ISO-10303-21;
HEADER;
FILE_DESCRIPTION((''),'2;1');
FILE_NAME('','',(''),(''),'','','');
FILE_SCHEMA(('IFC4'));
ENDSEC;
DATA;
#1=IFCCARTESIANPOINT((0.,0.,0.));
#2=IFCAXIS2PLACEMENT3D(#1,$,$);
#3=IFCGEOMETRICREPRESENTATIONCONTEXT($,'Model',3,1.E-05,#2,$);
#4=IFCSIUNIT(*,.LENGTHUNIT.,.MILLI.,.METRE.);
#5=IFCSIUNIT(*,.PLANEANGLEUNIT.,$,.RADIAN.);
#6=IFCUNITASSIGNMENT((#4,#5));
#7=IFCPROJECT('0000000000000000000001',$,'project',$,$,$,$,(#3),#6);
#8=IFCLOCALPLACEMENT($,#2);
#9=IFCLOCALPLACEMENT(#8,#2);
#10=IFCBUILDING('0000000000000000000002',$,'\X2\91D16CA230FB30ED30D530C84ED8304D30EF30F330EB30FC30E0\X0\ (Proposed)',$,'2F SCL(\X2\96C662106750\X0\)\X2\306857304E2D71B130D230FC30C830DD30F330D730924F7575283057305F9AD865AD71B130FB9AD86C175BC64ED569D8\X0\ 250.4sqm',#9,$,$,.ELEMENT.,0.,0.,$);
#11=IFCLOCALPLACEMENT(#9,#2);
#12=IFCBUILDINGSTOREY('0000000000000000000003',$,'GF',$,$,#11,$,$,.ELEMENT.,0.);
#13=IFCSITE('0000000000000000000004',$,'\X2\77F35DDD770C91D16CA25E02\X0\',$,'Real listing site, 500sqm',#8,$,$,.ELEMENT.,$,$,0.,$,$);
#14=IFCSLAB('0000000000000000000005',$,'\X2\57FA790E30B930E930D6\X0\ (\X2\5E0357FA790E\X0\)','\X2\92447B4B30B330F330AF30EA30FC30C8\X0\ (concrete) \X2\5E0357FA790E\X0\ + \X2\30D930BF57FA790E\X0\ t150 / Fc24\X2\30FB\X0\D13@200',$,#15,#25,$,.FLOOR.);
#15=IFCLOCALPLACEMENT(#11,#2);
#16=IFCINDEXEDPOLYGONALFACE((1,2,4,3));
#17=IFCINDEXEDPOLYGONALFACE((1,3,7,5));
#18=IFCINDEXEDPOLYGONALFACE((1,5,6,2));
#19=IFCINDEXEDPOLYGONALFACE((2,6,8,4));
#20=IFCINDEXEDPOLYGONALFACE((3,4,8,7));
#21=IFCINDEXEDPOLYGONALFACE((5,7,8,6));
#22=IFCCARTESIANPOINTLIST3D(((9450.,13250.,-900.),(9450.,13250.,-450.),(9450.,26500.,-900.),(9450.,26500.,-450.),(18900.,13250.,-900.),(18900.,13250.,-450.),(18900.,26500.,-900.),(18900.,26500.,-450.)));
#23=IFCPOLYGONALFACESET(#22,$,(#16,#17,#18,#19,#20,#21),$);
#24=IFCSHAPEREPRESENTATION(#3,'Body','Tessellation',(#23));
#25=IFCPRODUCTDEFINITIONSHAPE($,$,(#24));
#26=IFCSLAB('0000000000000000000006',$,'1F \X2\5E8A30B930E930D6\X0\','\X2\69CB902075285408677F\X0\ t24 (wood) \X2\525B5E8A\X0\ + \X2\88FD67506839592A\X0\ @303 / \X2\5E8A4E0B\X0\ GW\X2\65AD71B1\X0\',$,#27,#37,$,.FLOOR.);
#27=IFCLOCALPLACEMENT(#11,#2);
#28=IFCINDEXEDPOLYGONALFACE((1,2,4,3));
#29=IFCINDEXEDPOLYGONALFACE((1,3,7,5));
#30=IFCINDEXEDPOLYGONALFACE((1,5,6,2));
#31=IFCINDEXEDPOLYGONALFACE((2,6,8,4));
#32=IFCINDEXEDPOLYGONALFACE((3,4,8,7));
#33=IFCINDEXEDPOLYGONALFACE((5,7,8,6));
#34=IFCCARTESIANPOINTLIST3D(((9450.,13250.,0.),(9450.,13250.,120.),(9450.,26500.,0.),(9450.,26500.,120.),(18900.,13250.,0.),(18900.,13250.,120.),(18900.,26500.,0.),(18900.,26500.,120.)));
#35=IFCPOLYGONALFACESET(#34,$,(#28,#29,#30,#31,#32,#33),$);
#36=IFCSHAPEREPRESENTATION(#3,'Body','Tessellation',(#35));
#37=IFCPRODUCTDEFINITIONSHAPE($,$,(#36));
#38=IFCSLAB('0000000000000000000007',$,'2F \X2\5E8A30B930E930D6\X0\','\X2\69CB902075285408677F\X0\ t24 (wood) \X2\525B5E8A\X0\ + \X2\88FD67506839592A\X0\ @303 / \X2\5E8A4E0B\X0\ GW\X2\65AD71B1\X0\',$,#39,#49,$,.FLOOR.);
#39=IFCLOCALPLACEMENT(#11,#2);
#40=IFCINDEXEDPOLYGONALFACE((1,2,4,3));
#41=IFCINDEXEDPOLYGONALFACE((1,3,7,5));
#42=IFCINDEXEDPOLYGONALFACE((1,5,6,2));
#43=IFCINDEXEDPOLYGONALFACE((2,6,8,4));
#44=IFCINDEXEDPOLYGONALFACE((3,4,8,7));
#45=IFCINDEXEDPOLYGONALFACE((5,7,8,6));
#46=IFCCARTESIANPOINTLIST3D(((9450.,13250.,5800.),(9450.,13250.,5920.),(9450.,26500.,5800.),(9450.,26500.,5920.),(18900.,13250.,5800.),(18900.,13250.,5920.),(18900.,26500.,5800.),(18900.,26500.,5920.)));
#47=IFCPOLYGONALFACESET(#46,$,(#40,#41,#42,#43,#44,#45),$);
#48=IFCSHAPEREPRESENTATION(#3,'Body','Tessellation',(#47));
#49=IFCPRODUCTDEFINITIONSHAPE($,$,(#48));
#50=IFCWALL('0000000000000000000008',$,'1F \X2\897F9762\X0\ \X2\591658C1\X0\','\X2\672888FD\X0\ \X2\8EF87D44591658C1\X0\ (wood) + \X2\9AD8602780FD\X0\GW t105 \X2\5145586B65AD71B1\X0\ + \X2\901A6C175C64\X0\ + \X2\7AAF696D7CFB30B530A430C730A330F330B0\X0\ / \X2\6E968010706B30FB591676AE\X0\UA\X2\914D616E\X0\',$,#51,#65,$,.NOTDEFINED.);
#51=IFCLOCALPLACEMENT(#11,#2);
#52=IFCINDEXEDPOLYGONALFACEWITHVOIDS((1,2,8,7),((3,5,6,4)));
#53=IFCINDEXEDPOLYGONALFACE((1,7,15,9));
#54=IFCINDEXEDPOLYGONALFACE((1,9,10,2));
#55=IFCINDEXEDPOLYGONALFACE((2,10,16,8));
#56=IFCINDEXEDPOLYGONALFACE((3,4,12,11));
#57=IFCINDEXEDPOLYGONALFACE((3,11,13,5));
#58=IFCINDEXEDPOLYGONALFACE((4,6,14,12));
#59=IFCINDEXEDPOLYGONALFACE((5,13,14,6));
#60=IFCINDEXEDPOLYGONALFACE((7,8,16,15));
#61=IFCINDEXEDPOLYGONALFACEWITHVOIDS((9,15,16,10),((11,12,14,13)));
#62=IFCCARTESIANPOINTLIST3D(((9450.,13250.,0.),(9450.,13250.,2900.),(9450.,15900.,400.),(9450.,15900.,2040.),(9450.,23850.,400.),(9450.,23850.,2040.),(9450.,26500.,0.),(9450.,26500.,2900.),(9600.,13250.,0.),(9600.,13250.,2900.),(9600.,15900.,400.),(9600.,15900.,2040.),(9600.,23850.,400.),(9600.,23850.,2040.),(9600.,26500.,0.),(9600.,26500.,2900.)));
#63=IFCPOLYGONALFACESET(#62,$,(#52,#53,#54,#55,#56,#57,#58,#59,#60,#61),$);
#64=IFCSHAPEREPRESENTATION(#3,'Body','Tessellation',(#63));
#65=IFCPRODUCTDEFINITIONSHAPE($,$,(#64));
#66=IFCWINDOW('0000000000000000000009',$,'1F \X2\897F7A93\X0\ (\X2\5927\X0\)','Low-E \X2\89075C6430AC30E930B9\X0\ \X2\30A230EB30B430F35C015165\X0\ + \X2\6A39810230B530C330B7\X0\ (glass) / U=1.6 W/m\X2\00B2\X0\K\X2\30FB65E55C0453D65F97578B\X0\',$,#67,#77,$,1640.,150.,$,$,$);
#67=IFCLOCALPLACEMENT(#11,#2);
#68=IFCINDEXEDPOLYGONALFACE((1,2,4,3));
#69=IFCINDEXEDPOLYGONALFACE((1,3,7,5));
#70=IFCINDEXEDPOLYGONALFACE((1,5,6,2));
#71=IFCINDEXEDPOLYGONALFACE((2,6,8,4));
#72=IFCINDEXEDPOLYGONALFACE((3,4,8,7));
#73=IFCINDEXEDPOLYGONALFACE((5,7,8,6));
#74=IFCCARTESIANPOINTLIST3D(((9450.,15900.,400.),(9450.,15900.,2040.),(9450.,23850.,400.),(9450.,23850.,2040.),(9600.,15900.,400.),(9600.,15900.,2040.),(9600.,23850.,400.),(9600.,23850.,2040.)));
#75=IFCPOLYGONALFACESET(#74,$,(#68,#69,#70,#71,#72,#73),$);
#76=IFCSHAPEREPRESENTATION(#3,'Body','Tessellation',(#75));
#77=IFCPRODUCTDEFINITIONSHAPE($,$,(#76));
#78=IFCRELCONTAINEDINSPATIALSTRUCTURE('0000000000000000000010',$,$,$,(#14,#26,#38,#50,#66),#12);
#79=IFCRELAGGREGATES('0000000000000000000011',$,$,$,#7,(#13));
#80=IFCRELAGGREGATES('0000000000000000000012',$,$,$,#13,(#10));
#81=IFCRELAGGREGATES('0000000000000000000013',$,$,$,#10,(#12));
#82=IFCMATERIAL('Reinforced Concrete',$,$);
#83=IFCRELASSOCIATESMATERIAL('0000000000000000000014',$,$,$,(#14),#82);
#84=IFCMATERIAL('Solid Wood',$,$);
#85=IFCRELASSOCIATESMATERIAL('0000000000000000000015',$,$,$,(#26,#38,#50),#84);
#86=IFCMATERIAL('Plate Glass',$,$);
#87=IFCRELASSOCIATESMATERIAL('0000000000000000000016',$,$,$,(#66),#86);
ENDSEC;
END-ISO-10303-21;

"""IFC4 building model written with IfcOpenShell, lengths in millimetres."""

from ifc_helpers import new_model, si_unit, frame, frame_2d, origin, place, context, project, spatial, rectangle, extrude, material, element, fill, save


model = new_model("IFC4")

# Units and contexts
model_context = context("Model", 3, precision=1e-05, world=origin())
ifc_project = project(units=[si_unit("LENGTHUNIT", "METRE", prefix="MILLI"), si_unit("PLANEANGLEUNIT", "RADIAN")], contexts=[model_context])

# Site, building, storey
site_placement = place(None, origin())
site = spatial("IfcSite", under=ifc_project, at=site_placement, Name="石川県金沢市", ObjectType="Real listing site, 500sqm", CompositionType="ELEMENT", RefElevation=0.0)
building_placement = place(site_placement, origin())
building = spatial("IfcBuilding", under=site, at=building_placement, Name="金沢・ロフト付きワンルーム (Proposed)", ObjectType="2F SCL(集成材)と地中熱ヒートポンプを併用した高断熱・高気密仕様 250.4sqm", CompositionType="ELEMENT", ElevationOfRefHeight=0.0, ElevationOfTerrain=0.0)
storey_placement = place(building_placement, origin())
storey = spatial("IfcBuildingStorey", under=building, at=storey_placement, Name="GF", CompositionType="ELEMENT", Elevation=0.0)

# Shared definitions
ifc_material_1 = material(Name="Solid Wood")

# Slabs
ifc_material_2 = material(Name="Reinforced Concrete")
slab_1_placement = place(storey_placement, frame((4725.0, 6625.0, -450.0)))
element("IfcSlab", 1, at=slab_1_placement, inside=storey, material=ifc_material_2, Name="基礎スラブ (布基礎)", Description="鉄筋コンクリート (concrete) 布基礎 + ベタ基礎 t150 / Fc24・D13@200", PredefinedType="FLOOR", context=model_context, shape_type="SweptSolid", body=[
    extrude(rectangle(XDim=9450.0, YDim=13250.0, at=frame_2d((4725.0, 6625.0))), frame((4725.0, 6625.0, -450.0)), (0.0, 0.0, 1.0), 450.0),
])
slab_2_placement = place(storey_placement, frame((4725.0, 6625.0, 0.0)))
element("IfcSlab", 2, at=slab_2_placement, inside=storey, material=ifc_material_1, Name="1F 床スラブ", Description="構造用合板 t24 (wood) 剛床 + 製材根太 @303 / 床下 GW断熱", PredefinedType="FLOOR", context=model_context, shape_type="SweptSolid", body=[
    extrude(rectangle(XDim=9450.0, YDim=13250.0, at=frame_2d((4725.0, 6625.0))), frame((4725.0, 6625.0, 0.0)), (0.0, 0.0, 1.0), 120.0),
])
slab_3_placement = place(storey_placement, frame((4725.0, 6625.0, 2900.0)))
element("IfcSlab", 3, at=slab_3_placement, inside=storey, material=ifc_material_1, Name="2F 床スラブ", Description="構造用合板 t24 (wood) 剛床 + 製材根太 @303 / 床下 GW断熱", PredefinedType="FLOOR", context=model_context, shape_type="SweptSolid", body=[
    extrude(rectangle(XDim=9450.0, YDim=13250.0, at=frame_2d((4725.0, 6625.0))), frame((4725.0, 6625.0, 2900.0)), (0.0, 0.0, 1.0), 120.0),
])

# Shared definitions
ifc_material_3 = material(Name="Plate Glass")

# Wall, opening, window
wall_1_placement = place(storey_placement, frame((4725.0, 6625.0, 0.0)))
wall_1 = element("IfcWall", 4, at=wall_1_placement, inside=storey, material=ifc_material_1, Name="1F 西面 外壁", Description="木製 軸組外壁 (wood) + 高性能GW t105 充填断熱 + 通気層 + 窯業系サイディング / 準耐火・外皮UA配慮", PredefinedType="NOTDEFINED", context=model_context, shape_type="SweptSolid", body=[
    extrude(rectangle(XDim=150.0, YDim=13250.0, at=frame_2d((75.0, 6625.0))), frame((4725.0, 6625.0, 0.0)), (0.0, 0.0, 1.0), 2900.0),
])
opening_1_placement = place(storey_placement, frame((4725.0, 7950.0, 200.0)))
opening_1 = element("IfcOpeningElement", 5, at=opening_1_placement, cuts=wall_1, PredefinedType="NOTDEFINED", context=model_context, shape_type="SweptSolid", body=[
    extrude(rectangle(XDim=150.0, YDim=7950.0, at=frame_2d((75.0, 3975.0))), frame((4725.0, 7950.0, 200.0)), (0.0, 0.0, 1.0), 1640.0),
])
window_1_placement = place(storey_placement, frame((4725.0, 7950.0, 200.0)))
window_1 = element("IfcWindow", 6, at=window_1_placement, inside=storey, material=ifc_material_3, Name="1F 西窓 (大)", Description="Low-E 複層ガラス アルゴン封入 + 樹脂サッシ (glass) / U=1.6 W/m²K・日射取得型", OverallHeight=1640.0, OverallWidth=150.0, context=model_context, shape_type="SweptSolid", body=[
    extrude(rectangle(XDim=150.0, YDim=7950.0, at=frame_2d((75.0, 3975.0))), frame((4725.0, 7950.0, 200.0)), (0.0, 0.0, 1.0), 1640.0),
])
fill(opening_1, window_1)

save(model, "model.ifc")
